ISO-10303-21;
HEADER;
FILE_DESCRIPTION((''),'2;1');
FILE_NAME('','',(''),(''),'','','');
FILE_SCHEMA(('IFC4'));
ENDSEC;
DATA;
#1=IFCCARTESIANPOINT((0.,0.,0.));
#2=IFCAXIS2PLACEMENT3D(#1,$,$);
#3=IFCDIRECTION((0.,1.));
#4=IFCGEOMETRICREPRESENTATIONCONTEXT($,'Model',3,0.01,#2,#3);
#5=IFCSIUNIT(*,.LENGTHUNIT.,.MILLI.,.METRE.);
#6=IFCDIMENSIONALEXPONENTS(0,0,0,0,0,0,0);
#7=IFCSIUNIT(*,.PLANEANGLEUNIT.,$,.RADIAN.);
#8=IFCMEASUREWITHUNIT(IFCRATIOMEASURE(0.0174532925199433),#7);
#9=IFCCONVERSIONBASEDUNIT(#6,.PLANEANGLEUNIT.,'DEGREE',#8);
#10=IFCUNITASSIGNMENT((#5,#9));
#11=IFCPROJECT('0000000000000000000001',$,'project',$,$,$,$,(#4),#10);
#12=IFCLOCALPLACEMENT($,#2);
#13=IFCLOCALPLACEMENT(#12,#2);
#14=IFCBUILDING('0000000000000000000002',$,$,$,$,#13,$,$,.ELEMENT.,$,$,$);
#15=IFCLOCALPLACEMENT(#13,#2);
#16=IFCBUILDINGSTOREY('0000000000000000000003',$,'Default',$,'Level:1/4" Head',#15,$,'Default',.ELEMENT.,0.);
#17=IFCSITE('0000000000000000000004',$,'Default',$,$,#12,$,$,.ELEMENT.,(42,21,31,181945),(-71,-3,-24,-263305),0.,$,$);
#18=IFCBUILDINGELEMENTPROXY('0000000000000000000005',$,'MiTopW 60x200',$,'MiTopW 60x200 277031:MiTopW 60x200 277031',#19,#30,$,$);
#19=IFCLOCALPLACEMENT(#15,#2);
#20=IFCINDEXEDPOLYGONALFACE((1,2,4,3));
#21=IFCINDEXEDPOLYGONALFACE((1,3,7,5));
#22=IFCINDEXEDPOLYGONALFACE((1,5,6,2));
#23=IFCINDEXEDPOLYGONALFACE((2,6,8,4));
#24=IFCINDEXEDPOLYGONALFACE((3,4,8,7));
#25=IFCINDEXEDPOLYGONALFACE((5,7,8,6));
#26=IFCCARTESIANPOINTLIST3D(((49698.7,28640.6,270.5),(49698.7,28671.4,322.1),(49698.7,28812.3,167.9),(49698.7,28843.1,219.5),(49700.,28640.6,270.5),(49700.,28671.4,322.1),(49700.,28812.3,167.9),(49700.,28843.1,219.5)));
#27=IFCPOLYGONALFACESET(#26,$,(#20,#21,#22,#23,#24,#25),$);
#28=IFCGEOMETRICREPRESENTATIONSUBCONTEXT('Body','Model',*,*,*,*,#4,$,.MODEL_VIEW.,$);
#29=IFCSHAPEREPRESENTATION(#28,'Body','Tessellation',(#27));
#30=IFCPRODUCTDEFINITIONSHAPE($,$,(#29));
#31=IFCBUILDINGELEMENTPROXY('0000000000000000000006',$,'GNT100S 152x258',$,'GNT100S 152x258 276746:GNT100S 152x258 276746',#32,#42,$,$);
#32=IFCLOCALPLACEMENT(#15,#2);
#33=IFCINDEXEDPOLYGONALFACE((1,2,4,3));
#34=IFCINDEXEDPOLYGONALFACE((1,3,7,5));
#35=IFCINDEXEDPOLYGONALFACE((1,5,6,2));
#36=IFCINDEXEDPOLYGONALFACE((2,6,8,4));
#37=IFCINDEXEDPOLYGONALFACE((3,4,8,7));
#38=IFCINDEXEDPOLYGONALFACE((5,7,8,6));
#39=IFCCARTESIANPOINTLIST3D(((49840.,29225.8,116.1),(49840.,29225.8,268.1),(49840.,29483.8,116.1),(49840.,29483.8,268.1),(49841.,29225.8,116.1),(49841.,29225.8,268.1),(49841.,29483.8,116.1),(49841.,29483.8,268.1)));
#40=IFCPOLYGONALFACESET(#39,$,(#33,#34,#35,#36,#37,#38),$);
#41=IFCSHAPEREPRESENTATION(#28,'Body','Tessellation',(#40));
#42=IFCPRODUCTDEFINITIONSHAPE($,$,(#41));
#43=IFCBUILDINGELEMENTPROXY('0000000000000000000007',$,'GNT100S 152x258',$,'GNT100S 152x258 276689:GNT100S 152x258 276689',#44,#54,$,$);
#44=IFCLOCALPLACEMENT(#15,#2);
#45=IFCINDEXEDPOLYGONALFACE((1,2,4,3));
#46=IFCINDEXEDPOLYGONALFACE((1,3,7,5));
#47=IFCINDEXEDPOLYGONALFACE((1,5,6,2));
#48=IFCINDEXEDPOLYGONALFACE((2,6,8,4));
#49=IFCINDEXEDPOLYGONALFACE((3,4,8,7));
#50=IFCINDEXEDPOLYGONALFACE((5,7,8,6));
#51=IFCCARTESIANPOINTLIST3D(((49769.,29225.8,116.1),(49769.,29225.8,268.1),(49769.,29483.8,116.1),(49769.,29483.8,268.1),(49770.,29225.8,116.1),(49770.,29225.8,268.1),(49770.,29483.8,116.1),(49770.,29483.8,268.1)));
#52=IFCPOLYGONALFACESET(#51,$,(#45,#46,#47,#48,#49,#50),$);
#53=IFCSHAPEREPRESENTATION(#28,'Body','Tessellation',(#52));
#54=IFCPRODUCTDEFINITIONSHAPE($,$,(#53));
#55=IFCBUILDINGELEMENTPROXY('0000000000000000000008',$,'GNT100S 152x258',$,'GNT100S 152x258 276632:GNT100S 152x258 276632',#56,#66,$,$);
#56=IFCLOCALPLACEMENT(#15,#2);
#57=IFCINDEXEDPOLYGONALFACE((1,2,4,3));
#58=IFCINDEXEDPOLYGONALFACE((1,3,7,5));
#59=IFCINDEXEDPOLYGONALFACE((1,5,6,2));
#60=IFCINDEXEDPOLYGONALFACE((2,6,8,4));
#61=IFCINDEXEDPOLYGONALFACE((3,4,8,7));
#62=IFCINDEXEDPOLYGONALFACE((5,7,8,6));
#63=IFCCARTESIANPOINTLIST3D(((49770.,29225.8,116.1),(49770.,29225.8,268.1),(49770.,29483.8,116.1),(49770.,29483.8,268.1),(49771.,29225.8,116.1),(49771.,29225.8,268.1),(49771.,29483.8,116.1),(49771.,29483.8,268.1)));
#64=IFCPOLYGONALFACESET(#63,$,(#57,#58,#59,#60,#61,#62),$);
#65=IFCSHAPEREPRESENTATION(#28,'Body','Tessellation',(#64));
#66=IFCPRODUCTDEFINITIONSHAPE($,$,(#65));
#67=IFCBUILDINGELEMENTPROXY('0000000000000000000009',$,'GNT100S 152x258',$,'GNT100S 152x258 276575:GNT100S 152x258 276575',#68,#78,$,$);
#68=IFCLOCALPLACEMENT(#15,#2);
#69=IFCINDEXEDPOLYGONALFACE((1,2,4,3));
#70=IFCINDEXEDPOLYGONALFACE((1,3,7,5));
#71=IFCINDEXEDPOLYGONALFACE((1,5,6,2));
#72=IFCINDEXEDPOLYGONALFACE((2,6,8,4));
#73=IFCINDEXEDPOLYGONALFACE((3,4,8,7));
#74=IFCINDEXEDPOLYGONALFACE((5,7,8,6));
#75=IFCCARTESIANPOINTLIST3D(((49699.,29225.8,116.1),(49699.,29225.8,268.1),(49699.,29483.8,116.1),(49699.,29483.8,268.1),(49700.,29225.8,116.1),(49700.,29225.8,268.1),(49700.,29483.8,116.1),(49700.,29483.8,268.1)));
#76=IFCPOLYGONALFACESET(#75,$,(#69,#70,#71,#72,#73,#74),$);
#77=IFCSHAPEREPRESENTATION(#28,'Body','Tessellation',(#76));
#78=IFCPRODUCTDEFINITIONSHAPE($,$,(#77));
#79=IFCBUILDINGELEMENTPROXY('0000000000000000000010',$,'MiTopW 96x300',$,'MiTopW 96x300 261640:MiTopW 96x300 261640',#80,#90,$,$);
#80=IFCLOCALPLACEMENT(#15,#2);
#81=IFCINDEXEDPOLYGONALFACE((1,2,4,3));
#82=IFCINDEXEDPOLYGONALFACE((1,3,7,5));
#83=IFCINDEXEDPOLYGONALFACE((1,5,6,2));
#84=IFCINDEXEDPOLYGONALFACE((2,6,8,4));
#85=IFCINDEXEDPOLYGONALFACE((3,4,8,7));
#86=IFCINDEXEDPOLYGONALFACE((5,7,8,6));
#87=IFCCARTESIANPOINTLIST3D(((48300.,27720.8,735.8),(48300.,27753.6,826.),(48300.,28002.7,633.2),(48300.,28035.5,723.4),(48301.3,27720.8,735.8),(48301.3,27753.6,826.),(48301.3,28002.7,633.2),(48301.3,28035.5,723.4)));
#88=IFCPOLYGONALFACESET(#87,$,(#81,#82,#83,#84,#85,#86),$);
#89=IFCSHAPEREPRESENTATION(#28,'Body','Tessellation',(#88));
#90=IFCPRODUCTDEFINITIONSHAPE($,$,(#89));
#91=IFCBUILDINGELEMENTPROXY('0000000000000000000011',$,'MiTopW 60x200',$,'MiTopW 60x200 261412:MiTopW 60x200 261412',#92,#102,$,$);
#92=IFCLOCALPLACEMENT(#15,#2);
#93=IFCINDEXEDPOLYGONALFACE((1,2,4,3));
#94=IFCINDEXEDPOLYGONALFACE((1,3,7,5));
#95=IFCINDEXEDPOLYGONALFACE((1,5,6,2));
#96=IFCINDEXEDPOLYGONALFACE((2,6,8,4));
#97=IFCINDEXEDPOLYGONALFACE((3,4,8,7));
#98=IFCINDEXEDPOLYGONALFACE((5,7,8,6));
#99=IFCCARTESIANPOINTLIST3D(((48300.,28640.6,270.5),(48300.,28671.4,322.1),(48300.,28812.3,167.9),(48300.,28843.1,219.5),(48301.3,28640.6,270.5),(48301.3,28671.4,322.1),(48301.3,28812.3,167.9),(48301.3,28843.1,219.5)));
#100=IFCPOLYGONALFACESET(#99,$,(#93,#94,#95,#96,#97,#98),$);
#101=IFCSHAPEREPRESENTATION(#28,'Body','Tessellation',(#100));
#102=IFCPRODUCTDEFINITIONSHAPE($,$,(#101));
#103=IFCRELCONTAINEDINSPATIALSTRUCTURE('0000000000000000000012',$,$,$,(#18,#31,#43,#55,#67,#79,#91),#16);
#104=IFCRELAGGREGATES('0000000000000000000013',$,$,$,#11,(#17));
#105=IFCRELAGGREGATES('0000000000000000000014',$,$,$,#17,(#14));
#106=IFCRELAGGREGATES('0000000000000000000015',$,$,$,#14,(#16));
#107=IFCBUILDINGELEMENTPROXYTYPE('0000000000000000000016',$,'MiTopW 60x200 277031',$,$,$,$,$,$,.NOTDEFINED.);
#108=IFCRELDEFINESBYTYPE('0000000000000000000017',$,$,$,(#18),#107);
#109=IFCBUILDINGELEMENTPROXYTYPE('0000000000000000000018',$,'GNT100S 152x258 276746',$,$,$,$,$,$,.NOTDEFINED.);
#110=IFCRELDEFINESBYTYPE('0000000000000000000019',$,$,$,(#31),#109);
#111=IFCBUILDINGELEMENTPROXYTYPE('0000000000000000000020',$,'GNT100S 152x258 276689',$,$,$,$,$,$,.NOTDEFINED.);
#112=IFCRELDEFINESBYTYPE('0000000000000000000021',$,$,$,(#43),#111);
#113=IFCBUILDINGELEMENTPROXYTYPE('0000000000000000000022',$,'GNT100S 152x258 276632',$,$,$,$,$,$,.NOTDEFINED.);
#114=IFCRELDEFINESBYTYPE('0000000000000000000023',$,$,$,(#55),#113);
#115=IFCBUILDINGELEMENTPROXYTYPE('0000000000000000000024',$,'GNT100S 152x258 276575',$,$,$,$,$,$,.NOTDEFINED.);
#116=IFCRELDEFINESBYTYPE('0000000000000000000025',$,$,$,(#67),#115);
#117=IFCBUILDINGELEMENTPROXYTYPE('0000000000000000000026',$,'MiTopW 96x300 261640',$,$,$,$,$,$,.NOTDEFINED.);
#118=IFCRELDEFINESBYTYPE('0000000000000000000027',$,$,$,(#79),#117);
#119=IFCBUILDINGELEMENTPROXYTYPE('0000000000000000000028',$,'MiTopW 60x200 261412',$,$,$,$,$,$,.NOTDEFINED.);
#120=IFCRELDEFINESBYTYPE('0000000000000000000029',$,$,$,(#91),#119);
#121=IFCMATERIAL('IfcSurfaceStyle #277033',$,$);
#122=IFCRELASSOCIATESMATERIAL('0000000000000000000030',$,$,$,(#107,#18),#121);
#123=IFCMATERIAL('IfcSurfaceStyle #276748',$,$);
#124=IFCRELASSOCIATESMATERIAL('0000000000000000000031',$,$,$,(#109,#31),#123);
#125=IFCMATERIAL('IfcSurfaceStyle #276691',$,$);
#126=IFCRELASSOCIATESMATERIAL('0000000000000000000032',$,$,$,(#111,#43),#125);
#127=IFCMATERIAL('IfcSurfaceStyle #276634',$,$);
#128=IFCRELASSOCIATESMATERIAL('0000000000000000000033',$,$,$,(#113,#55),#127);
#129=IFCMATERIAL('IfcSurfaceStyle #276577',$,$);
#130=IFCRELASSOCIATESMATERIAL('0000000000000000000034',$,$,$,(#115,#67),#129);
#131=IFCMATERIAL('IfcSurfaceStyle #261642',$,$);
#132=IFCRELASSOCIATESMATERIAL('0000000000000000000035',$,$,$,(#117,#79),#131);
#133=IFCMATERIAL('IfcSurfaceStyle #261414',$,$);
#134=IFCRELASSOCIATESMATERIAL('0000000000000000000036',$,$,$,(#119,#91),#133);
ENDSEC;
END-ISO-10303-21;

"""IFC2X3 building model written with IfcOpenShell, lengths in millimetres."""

from ifc_helpers import new_model, entity, si_unit, converted_unit, direction, frame, origin, origin_2d_with_axis, place, context, subcontext, project, spatial, polyline, rectangle, outline, extrude, source, transform, mapped, material, type_object, type_shapes, element, save


model = new_model("IFC2X3")

# Units and contexts
model_context = context("Model", 3, precision=0.01, world=origin(), true_north=direction((0.0, 1.0)))
body_context = subcontext(model_context, "Body", "Model", "MODEL_VIEW")
ifc_project = project(units=[si_unit("LENGTHUNIT", "METRE", prefix="MILLI"), converted_unit("PLANEANGLEUNIT", "DEGREE", entity("IfcRatioMeasure", 0.0174532925199433), si_unit("PLANEANGLEUNIT", "RADIAN"), dimensions=[0, 0, 0, 0, 0, 0, 0])], contexts=[model_context])

# Site, building, storey
site_placement = place(None, origin())
site = spatial("IfcSite", under=ifc_project, at=site_placement, Name="Default", CompositionType="ELEMENT", RefLatitude=(42, 21, 31, 181945), RefLongitude=(-71, -3, -24, -263305), RefElevation=0.0)
building_placement = place(site_placement, origin())
building = spatial("IfcBuilding", under=site, at=building_placement, CompositionType="ELEMENT")
storey_placement = place(building_placement, origin())
storey = spatial("IfcBuildingStorey", under=building, at=storey_placement, Name="Default", ObjectType="Level:1/4\" Head", LongName="Default", CompositionType="ELEMENT", Elevation=0.0)

# Building element proxies
ifc_material_1 = material(Name="IfcSurfaceStyle #277033")
building_element_proxy_type_1 = type_object("IfcBuildingElementProxyType", Name="MiTopW 60x200 277031", PredefinedType="NOTDEFINED", material=ifc_material_1)
shared_shape_1 = source(origin(), body_context, "Body", "SweptSolid", [
    extrude(outline(polyline([(-100.0, -30.0), (100.0, -30.0), (100.0, 30.0), (-100.0, 30.0), (-100.0, -30.0)])), frame((100.0, 30.0, 0.0), z_axis=(0.0, 0.0, 1.0), x_axis=(-1.0, 0.0, 0.0)), (0.0, 0.0, 1.0), 1.3),
])
type_shapes(building_element_proxy_type_1, [shared_shape_1])
proxy_1_placement = place(building_placement, frame((49700.0, 28812.3, 167.9), z_axis=(-1.0, 0.0, 0.0), x_axis=(0.0, -0.858392, 0.512994)))
element("IfcBuildingElementProxy", 1, at=proxy_1_placement, inside=storey, type_object=building_element_proxy_type_1, material=ifc_material_1, Name="MiTopW 60x200", ObjectType="MiTopW 60x200 277031:MiTopW 60x200 277031", context=body_context, shape_type="MappedRepresentation", body=[
    mapped(shared_shape_1, transform((0.0, 0.0, 0.0), scale=1.0)),
])
ifc_material_2 = material(Name="IfcSurfaceStyle #276748")
building_element_proxy_type_2 = type_object("IfcBuildingElementProxyType", Name="GNT100S 152x258 276746", PredefinedType="NOTDEFINED", material=ifc_material_2)
shared_shape_2 = source(origin(), body_context, "Body", "SweptSolid", [
    extrude(rectangle(XDim=258.0, YDim=152.0, at=origin_2d_with_axis()), frame((129.0, 76.0, 0.0), z_axis=(0.0, 0.0, 1.0), x_axis=(-1.0, 0.0, 0.0)), (0.0, 0.0, 1.0), 1.0),
])
type_shapes(building_element_proxy_type_2, [shared_shape_2])
proxy_2_placement = place(building_placement, frame((49841.0, 29483.8, 116.1), z_axis=(-1.0, 0.0, 0.0), x_axis=(0.0, -1.0, 0.0)))
element("IfcBuildingElementProxy", 2, at=proxy_2_placement, inside=storey, type_object=building_element_proxy_type_2, material=ifc_material_2, Name="GNT100S 152x258", ObjectType="GNT100S 152x258 276746:GNT100S 152x258 276746", context=body_context, shape_type="MappedRepresentation", body=[
    mapped(shared_shape_2, transform((0.0, 0.0, 0.0), scale=1.0)),
])
ifc_material_3 = material(Name="IfcSurfaceStyle #276691")
building_element_proxy_type_3 = type_object("IfcBuildingElementProxyType", Name="GNT100S 152x258 276689", PredefinedType="NOTDEFINED", material=ifc_material_3)
shared_shape_3 = source(origin(), body_context, "Body", "SweptSolid", [
    extrude(rectangle(XDim=258.0, YDim=152.0, at=origin_2d_with_axis()), frame((129.0, 76.0, 0.0), z_axis=(0.0, 0.0, 1.0), x_axis=(-1.0, 0.0, 0.0)), (0.0, 0.0, 1.0), 1.0),
])
type_shapes(building_element_proxy_type_3, [shared_shape_3])
proxy_3_placement = place(building_placement, frame((49770.0, 29483.8, 116.1), z_axis=(-1.0, 0.0, 0.0), x_axis=(0.0, -1.0, 0.0)))
element("IfcBuildingElementProxy", 3, at=proxy_3_placement, inside=storey, type_object=building_element_proxy_type_3, material=ifc_material_3, Name="GNT100S 152x258", ObjectType="GNT100S 152x258 276689:GNT100S 152x258 276689", context=body_context, shape_type="MappedRepresentation", body=[
    mapped(shared_shape_3, transform((0.0, 0.0, 0.0), scale=1.0)),
])
ifc_material_4 = material(Name="IfcSurfaceStyle #276634")
building_element_proxy_type_4 = type_object("IfcBuildingElementProxyType", Name="GNT100S 152x258 276632", PredefinedType="NOTDEFINED", material=ifc_material_4)
shared_shape_4 = source(origin(), body_context, "Body", "SweptSolid", [
    extrude(rectangle(XDim=258.0, YDim=152.0, at=origin_2d_with_axis()), frame((129.0, 76.0, 0.0), z_axis=(0.0, 0.0, 1.0), x_axis=(-1.0, 0.0, 0.0)), (0.0, 0.0, 1.0), 1.0),
])
type_shapes(building_element_proxy_type_4, [shared_shape_4])
proxy_4_placement = place(building_placement, frame((49771.0, 29483.8, 116.1), z_axis=(-1.0, 0.0, 0.0), x_axis=(0.0, -1.0, 0.0)))
element("IfcBuildingElementProxy", 4, at=proxy_4_placement, inside=storey, type_object=building_element_proxy_type_4, material=ifc_material_4, Name="GNT100S 152x258", ObjectType="GNT100S 152x258 276632:GNT100S 152x258 276632", context=body_context, shape_type="MappedRepresentation", body=[
    mapped(shared_shape_4, transform((0.0, 0.0, 0.0), scale=1.0)),
])
ifc_material_5 = material(Name="IfcSurfaceStyle #276577")
building_element_proxy_type_5 = type_object("IfcBuildingElementProxyType", Name="GNT100S 152x258 276575", PredefinedType="NOTDEFINED", material=ifc_material_5)
shared_shape_5 = source(origin(), body_context, "Body", "SweptSolid", [
    extrude(rectangle(XDim=258.0, YDim=152.0, at=origin_2d_with_axis()), frame((129.0, 76.0, 0.0), z_axis=(0.0, 0.0, 1.0), x_axis=(-1.0, 0.0, 0.0)), (0.0, 0.0, 1.0), 1.0),
])
type_shapes(building_element_proxy_type_5, [shared_shape_5])
proxy_5_placement = place(building_placement, frame((49700.0, 29483.8, 116.1), z_axis=(-1.0, 0.0, 0.0), x_axis=(0.0, -1.0, 0.0)))
element("IfcBuildingElementProxy", 5, at=proxy_5_placement, inside=storey, type_object=building_element_proxy_type_5, material=ifc_material_5, Name="GNT100S 152x258", ObjectType="GNT100S 152x258 276575:GNT100S 152x258 276575", context=body_context, shape_type="MappedRepresentation", body=[
    mapped(shared_shape_5, transform((0.0, 0.0, 0.0), scale=1.0)),
])
ifc_material_6 = material(Name="IfcSurfaceStyle #261642")
building_element_proxy_type_6 = type_object("IfcBuildingElementProxyType", Name="MiTopW 96x300 261640", PredefinedType="NOTDEFINED", material=ifc_material_6)
shared_shape_6 = source(origin(), body_context, "Body", "SweptSolid", [
    extrude(outline(polyline([(-150.0, -48.0), (150.0, -48.0), (150.0, 48.0), (-150.0, 48.0), (-150.0, -48.0)])), frame((150.0, 48.0, 0.0), z_axis=(0.0, 0.0, 1.0), x_axis=(-1.0, 0.0, 0.0)), (0.0, 0.0, 1.0), 1.3),
])
type_shapes(building_element_proxy_type_6, [shared_shape_6])
proxy_6_placement = place(building_placement, frame((48301.3, 28002.7, 633.2), z_axis=(-1.0, 0.0, 0.0), x_axis=(0.0, -0.939693, 0.34202)))
element("IfcBuildingElementProxy", 6, at=proxy_6_placement, inside=storey, type_object=building_element_proxy_type_6, material=ifc_material_6, Name="MiTopW 96x300", ObjectType="MiTopW 96x300 261640:MiTopW 96x300 261640", context=body_context, shape_type="MappedRepresentation", body=[
    mapped(shared_shape_6, transform((0.0, 0.0, 0.0), scale=1.0)),
])
ifc_material_7 = material(Name="IfcSurfaceStyle #261414")
building_element_proxy_type_7 = type_object("IfcBuildingElementProxyType", Name="MiTopW 60x200 261412", PredefinedType="NOTDEFINED", material=ifc_material_7)
shared_shape_7 = source(origin(), body_context, "Body", "SweptSolid", [
    extrude(outline(polyline([(-100.0, -30.0), (100.0, -30.0), (100.0, 30.0), (-100.0, 30.0), (-100.0, -30.0)])), frame((100.0, 30.0, 0.0), z_axis=(0.0, 0.0, 1.0), x_axis=(-1.0, 0.0, 0.0)), (0.0, 0.0, 1.0), 1.3),
])
type_shapes(building_element_proxy_type_7, [shared_shape_7])
proxy_7_placement = place(building_placement, frame((48301.3, 28812.3, 167.9), z_axis=(-1.0, 0.0, 0.0), x_axis=(0.0, -0.858392, 0.512994)))
element("IfcBuildingElementProxy", 7, at=proxy_7_placement, inside=storey, type_object=building_element_proxy_type_7, material=ifc_material_7, Name="MiTopW 60x200", ObjectType="MiTopW 60x200 261412:MiTopW 60x200 261412", context=body_context, shape_type="MappedRepresentation", body=[
    mapped(shared_shape_7, transform((0.0, 0.0, 0.0), scale=1.0)),
])

save(model, "model.ifc")
